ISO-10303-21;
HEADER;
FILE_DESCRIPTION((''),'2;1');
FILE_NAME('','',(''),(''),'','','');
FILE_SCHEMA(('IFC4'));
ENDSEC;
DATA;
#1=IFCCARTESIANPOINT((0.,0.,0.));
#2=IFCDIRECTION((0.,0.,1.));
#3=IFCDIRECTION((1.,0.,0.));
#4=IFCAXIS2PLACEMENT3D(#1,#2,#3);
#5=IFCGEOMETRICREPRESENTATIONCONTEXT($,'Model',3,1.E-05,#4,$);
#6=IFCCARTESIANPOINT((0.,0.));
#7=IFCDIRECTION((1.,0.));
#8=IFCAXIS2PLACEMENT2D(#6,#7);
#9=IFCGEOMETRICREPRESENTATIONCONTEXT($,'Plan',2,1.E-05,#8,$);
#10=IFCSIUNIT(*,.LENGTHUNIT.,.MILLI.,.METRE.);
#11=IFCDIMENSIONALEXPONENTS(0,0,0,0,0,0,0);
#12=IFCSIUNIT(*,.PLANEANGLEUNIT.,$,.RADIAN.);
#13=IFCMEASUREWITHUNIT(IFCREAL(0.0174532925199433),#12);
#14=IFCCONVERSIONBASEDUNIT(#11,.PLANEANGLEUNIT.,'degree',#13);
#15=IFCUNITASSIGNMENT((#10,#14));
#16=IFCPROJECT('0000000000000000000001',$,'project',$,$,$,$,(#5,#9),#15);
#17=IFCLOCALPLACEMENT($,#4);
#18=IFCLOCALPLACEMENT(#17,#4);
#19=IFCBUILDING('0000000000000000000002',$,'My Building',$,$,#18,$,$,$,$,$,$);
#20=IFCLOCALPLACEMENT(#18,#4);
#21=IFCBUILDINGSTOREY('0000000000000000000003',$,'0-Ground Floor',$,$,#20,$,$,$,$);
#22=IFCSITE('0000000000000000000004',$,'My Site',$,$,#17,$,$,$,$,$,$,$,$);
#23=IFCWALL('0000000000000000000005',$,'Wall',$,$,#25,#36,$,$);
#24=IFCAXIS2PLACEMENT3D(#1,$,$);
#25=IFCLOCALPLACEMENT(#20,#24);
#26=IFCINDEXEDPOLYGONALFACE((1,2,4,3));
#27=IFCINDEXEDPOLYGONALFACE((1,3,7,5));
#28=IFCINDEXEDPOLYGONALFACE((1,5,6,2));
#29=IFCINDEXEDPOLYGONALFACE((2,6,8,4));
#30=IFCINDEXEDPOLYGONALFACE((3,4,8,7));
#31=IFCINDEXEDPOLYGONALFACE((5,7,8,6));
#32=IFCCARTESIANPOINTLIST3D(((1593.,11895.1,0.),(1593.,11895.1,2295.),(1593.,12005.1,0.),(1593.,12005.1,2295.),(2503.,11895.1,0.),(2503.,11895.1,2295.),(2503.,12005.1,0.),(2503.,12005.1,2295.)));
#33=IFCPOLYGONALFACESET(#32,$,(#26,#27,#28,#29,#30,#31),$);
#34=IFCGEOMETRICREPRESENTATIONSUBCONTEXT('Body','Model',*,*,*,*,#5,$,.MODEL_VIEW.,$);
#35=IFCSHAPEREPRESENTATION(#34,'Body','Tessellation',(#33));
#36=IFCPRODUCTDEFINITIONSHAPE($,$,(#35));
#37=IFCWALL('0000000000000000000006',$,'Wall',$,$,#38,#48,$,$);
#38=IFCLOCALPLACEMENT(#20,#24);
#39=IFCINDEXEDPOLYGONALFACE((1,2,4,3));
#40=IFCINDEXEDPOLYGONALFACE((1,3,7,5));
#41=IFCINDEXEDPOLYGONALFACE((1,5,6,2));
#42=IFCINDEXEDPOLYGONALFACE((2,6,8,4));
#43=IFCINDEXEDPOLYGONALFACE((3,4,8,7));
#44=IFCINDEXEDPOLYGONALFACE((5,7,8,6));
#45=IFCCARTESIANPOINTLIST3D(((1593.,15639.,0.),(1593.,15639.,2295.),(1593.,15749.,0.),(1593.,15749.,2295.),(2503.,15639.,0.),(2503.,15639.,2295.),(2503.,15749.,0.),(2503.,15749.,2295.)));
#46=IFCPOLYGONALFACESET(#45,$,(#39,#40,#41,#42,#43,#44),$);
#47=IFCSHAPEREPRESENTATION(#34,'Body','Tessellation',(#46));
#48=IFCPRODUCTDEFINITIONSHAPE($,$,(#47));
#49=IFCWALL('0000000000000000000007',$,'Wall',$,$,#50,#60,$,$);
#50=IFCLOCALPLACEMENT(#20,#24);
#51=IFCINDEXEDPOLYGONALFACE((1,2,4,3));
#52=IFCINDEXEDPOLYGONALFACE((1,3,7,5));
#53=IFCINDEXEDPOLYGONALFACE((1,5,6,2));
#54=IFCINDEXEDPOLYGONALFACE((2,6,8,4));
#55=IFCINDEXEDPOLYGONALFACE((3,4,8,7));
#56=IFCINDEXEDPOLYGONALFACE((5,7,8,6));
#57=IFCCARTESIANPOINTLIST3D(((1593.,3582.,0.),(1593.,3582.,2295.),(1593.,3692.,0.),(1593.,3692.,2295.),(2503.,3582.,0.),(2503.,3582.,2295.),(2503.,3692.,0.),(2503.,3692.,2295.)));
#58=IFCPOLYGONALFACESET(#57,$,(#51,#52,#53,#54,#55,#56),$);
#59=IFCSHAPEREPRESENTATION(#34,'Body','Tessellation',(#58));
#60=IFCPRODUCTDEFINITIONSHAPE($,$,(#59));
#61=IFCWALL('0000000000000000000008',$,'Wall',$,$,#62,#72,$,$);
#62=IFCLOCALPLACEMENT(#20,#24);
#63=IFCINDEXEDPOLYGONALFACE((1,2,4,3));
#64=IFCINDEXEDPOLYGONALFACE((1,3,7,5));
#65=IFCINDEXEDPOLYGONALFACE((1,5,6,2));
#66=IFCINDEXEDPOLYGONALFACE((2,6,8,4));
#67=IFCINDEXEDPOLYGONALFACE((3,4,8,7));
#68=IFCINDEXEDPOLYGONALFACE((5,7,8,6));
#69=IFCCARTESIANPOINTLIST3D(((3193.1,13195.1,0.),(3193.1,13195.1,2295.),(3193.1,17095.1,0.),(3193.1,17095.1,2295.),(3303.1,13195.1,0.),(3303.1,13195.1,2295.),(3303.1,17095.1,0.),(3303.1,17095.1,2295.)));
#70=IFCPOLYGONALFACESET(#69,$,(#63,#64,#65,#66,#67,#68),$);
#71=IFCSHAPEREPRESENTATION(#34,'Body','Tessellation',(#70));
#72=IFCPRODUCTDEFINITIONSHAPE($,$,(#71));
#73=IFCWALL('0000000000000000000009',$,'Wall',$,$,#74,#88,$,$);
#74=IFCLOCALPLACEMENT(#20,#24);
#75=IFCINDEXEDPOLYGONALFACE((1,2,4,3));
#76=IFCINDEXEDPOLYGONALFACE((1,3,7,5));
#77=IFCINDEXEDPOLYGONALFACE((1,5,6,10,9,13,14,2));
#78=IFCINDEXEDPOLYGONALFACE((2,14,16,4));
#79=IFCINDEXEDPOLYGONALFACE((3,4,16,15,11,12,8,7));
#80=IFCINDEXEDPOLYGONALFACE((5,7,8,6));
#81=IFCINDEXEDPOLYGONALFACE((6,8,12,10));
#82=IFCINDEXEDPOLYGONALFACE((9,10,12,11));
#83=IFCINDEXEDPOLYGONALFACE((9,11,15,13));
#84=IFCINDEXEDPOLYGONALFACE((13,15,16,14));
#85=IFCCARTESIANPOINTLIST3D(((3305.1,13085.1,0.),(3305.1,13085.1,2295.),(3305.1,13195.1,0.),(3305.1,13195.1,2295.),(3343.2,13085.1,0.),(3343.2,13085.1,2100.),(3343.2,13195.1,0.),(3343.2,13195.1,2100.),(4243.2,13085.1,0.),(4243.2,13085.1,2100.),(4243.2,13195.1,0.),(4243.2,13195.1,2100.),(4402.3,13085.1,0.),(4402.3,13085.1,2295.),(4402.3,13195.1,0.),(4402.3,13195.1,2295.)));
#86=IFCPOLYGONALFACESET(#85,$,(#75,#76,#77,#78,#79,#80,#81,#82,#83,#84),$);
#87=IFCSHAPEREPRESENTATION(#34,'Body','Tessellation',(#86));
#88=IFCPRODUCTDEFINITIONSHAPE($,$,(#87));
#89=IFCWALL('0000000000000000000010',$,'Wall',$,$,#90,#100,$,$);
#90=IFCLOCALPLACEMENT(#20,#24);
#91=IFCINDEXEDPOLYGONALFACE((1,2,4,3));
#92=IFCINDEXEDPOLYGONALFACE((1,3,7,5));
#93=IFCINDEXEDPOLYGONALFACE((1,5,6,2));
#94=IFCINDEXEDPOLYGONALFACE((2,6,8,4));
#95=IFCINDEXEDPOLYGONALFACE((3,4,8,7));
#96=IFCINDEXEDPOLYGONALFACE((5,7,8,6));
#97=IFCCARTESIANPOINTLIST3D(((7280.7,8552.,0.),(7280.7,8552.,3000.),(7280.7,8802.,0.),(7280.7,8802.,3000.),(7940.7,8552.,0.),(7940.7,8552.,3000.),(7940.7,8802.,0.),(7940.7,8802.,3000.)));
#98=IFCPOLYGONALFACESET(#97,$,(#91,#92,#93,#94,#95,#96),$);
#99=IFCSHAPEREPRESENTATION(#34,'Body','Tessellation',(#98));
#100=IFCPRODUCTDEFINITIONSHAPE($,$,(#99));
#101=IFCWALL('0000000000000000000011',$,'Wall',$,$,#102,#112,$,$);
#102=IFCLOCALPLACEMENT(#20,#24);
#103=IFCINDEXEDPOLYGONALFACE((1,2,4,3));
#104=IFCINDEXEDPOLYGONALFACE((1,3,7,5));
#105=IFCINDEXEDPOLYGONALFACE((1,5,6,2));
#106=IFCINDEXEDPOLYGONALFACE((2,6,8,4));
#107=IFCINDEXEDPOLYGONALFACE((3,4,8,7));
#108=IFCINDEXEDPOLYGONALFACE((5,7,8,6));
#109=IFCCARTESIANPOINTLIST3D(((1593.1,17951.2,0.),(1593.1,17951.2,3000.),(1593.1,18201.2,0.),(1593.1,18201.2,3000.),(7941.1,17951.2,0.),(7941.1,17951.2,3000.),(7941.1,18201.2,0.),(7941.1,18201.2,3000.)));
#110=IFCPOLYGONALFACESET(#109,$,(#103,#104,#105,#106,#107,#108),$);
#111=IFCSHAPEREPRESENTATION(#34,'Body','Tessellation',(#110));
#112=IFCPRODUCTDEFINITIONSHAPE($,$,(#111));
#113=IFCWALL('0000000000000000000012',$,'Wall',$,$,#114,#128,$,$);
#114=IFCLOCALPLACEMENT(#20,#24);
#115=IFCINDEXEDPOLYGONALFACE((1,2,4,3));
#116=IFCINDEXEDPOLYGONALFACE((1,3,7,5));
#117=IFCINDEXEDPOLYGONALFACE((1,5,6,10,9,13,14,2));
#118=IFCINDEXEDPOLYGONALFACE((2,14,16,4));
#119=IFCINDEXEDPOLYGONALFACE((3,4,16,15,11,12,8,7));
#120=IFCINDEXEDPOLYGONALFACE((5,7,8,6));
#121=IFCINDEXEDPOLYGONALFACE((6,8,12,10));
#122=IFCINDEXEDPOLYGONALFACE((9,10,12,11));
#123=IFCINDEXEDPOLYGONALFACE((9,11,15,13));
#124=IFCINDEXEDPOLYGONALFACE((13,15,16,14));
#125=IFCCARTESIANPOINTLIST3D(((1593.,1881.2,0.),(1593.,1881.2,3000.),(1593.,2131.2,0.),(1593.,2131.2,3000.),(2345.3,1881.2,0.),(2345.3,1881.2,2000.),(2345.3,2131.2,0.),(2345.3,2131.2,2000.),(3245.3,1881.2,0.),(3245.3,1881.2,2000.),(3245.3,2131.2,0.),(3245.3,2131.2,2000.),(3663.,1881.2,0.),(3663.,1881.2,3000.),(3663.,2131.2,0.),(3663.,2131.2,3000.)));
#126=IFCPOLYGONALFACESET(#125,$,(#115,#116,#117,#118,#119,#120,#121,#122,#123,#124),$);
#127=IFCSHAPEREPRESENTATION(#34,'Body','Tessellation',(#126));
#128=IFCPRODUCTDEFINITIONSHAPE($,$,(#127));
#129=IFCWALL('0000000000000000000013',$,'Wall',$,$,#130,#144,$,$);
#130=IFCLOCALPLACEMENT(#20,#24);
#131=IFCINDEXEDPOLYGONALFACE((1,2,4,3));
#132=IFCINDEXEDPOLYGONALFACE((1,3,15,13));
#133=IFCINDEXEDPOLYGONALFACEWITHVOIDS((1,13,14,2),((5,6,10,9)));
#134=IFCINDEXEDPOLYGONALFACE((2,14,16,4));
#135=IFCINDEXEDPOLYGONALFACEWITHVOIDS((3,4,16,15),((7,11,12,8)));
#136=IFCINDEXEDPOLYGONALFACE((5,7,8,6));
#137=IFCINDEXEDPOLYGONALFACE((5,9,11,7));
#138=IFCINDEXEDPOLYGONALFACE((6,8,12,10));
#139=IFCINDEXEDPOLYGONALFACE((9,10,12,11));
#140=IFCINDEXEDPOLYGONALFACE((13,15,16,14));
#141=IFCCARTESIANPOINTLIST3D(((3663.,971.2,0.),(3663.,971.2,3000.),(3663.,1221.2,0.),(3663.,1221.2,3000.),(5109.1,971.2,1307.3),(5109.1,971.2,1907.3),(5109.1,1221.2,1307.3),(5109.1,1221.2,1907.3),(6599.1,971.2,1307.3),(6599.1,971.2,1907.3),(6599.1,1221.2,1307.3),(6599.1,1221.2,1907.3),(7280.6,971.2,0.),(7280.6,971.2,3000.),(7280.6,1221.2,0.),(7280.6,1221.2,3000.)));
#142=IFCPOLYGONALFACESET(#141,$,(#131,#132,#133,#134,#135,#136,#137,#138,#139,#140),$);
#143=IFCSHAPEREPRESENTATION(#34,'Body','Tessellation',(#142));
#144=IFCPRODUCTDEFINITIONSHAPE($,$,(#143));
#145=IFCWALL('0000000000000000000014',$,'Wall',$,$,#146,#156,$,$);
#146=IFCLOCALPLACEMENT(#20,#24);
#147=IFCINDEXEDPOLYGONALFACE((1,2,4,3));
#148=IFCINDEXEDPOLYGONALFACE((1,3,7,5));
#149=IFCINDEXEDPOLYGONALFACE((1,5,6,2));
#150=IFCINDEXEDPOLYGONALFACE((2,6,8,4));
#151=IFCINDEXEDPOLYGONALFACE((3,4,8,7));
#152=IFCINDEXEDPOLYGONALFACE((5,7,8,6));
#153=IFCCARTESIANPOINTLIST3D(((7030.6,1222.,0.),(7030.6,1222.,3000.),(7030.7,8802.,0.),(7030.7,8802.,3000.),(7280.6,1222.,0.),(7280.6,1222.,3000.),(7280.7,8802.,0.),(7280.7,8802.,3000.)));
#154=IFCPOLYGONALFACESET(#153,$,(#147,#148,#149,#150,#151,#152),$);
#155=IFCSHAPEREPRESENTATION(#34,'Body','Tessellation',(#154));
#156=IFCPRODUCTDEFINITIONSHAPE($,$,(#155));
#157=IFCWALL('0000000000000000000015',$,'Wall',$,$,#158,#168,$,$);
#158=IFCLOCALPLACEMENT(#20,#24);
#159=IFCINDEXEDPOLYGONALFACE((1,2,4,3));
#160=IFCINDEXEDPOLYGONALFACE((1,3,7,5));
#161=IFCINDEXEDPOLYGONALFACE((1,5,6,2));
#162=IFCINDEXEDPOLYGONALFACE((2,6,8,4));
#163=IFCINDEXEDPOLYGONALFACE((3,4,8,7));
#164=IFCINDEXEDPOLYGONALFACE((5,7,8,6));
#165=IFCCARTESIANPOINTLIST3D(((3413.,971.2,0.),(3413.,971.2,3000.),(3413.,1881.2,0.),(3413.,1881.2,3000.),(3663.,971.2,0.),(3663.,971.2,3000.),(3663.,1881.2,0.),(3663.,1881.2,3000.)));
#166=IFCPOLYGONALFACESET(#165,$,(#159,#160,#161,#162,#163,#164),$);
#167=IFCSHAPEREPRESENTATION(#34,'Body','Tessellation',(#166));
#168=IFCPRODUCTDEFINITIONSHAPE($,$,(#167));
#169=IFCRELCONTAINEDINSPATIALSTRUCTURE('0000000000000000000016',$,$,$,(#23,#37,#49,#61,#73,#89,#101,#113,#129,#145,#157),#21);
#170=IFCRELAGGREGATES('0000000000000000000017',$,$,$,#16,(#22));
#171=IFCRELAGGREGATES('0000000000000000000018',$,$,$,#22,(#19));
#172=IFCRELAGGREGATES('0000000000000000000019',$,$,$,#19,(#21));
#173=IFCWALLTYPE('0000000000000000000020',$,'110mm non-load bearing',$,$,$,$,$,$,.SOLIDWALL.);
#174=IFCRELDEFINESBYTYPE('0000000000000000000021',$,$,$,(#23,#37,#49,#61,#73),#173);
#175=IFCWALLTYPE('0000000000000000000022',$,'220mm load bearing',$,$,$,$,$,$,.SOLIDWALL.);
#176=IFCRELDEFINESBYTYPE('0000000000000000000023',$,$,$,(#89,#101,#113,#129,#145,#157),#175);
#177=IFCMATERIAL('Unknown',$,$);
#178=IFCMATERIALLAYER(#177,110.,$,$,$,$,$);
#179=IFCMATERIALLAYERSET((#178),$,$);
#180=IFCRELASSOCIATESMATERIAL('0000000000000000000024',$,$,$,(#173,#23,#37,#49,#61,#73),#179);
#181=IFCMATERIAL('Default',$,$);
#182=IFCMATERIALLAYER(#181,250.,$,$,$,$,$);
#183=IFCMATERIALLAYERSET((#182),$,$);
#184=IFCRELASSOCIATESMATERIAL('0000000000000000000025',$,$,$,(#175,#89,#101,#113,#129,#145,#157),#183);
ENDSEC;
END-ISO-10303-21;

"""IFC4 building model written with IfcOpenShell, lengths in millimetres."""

from ifc_helpers import new_model, entity, si_unit, converted_unit, frame, origin_with_axes, origin_2d_with_axis, place, context, subcontext, project, spatial, line, indexed_curve, outline, extrude, source, transform, mapped, material, layer, layer_set, layer_usage, type_object, element, save


model = new_model("IFC4")

# Units and contexts
model_context = context("Model", 3, precision=1e-05, world=origin_with_axes())
plan_context = context("Plan", 2, precision=1e-05, world=origin_2d_with_axis())
body_context_1 = subcontext(model_context, "Body", "Model", "MODEL_VIEW")
ifc_project = project(units=[si_unit("LENGTHUNIT", "METRE", prefix="MILLI"), converted_unit("PLANEANGLEUNIT", "degree", entity("IfcReal", 0.0174532925199433), si_unit("PLANEANGLEUNIT", "RADIAN"), dimensions=[0, 0, 0, 0, 0, 0, 0])], contexts=[model_context, plan_context])

# Site, building, storey
site_placement = place(None, origin_with_axes())
site = spatial("IfcSite", under=ifc_project, at=site_placement, Name="My Site")
building_placement = place(site_placement, origin_with_axes())
building = spatial("IfcBuilding", under=site, at=building_placement, Name="My Building")
storey_placement = place(building_placement, origin_with_axes())
storey = spatial("IfcBuildingStorey", under=building, at=storey_placement, Name="0-Ground Floor")

# Shared definitions
ifc_material_1 = material(Name="Unknown")
ifc_layer_1 = layer(ifc_material_1, 110.0)
ifc_layer_set_1 = layer_set([ifc_layer_1])
wall_type_1 = type_object("IfcWallType", Name="110mm non-load bearing", PredefinedType="SOLIDWALL", material=ifc_layer_set_1)

# Shared definitions
shared_shape_1 = source(origin_with_axes(), body_context_1, "Body", "SweptSolid", [
    extrude(outline(indexed_curve([(0.0, 0.0), (900.0, 0.0), (900.0, 2100.0), (0.0, 2100.0)], segments=[line(1, 2, 3, 4, 1)])), frame((0.0, -600.0, 0.0), z_axis=(0.0, -1.0, 0.0), x_axis=(1.0, 0.0, 0.0)), (0.0, 0.0, -1.0), 1200.0),
])

# Walls
ifc_layer_usage_1 = layer_usage(ifc_layer_set_1, "AXIS2", "POSITIVE", 0.0)
wall_1_placement = place(storey_placement, frame((1593.0, 11895.1, 0.0), z_axis=(0.0, 0.0, 1.0), x_axis=(1.0, 0.0, 0.0)))
element("IfcWall", 1, at=wall_1_placement, inside=storey, type_object=wall_type_1, material=ifc_layer_usage_1, Name="Wall", context=body_context_1, shape_type="SweptSolid", body=[
    extrude(outline(indexed_curve([(0.0, 0.0), (0.0, 110.0), (910.0, 110.0), (910.0, 0.0), (0.0, 0.0)], self_intersect=False)), origin_with_axes(), (0.0, 0.0, 1.0), 2295.0),
])
ifc_layer_usage_2 = layer_usage(ifc_layer_set_1, "AXIS2", "POSITIVE", 0.0)
wall_2_placement = place(storey_placement, frame((1593.0, 15639.0, 0.0), z_axis=(0.0, 0.0, 1.0), x_axis=(1.0, 0.0, 0.0)))
element("IfcWall", 2, at=wall_2_placement, inside=storey, type_object=wall_type_1, material=ifc_layer_usage_2, Name="Wall", context=body_context_1, shape_type="SweptSolid", body=[
    extrude(outline(indexed_curve([(0.0, 0.0), (0.0, 110.0), (910.0, 110.0), (910.0, 0.0), (0.0, 0.0)], self_intersect=False)), origin_with_axes(), (0.0, 0.0, 1.0), 2295.0),
])
ifc_layer_usage_3 = layer_usage(ifc_layer_set_1, "AXIS2", "POSITIVE", 0.0)
wall_3_placement = place(storey_placement, frame((1593.0, 3582.0, 0.0), z_axis=(0.0, 0.0, 1.0), x_axis=(1.0, 0.0, 0.0)))
element("IfcWall", 3, at=wall_3_placement, inside=storey, type_object=wall_type_1, material=ifc_layer_usage_3, Name="Wall", context=body_context_1, shape_type="SweptSolid", body=[
    extrude(outline(indexed_curve([(0.0, 0.0), (0.0, 110.0), (910.0, 110.0), (910.0, 0.0), (0.0, 0.0)], self_intersect=False)), origin_with_axes(), (0.0, 0.0, 1.0), 2295.0),
])
ifc_layer_usage_4 = layer_usage(ifc_layer_set_1, "AXIS2", "POSITIVE", 0.0)
wall_4_placement = place(storey_placement, frame((3303.1, 13195.1, 0.0), z_axis=(0.0, 0.0, 1.0), x_axis=(0.0, 1.0, 0.0)))
element("IfcWall", 4, at=wall_4_placement, inside=storey, type_object=wall_type_1, material=ifc_layer_usage_4, Name="Wall", context=body_context_1, shape_type="SweptSolid", body=[
    extrude(outline(indexed_curve([(0.0, 0.0), (0.0, 110.0), (3900.0, 110.0), (3900.0, 0.0), (0.0, 0.0)], self_intersect=False)), origin_with_axes(), (0.0, 0.0, 1.0), 2295.0),
])

# Wall, opening
ifc_layer_usage_5 = layer_usage(ifc_layer_set_1, "AXIS2", "POSITIVE", 0.0)
wall_5_placement = place(storey_placement, frame((3305.1, 13085.1, 0.0), z_axis=(0.0, 0.0, 1.0), x_axis=(1.0, 0.0, 0.0)))
wall_5 = element("IfcWall", 5, at=wall_5_placement, inside=storey, type_object=wall_type_1, material=ifc_layer_usage_5, Name="Wall", context=body_context_1, shape_type="SweptSolid", body=[
    extrude(outline(indexed_curve([(0.0, 0.0), (0.0, 110.0), (1097.3, 110.0), (1097.3, 0.0), (0.0, 0.0)], self_intersect=False)), origin_with_axes(), (0.0, 0.0, 1.0), 2295.0),
])
opening_1_placement = place(wall_5_placement, frame((38.2, 0.0, 0.0), z_axis=(0.0, 0.0, 1.0), x_axis=(1.0, 0.0, 0.0)))
element("IfcOpeningElement", 6, at=opening_1_placement, cuts=wall_5, PredefinedType="OPENING", context=body_context_1, shape_type="MappedRepresentation", body=[
    mapped(shared_shape_1, transform((0.0, 0.0, 0.0), x_axis=(1.0, 0.0, 0.0), y_axis=(0.0, 1.0, 0.0), z_axis=(0.0, 0.0, 1.0), scale=1.0)),
])

# Walls
ifc_material_2 = material(Name="Default")
ifc_layer_2 = layer(ifc_material_2, 250.0)
ifc_layer_set_2 = layer_set([ifc_layer_2])
ifc_layer_usage_6 = layer_usage(ifc_layer_set_2, "AXIS2", "POSITIVE", 0.0)
wall_type_2 = type_object("IfcWallType", Name="220mm load bearing", PredefinedType="SOLIDWALL", material=ifc_layer_set_2)
wall_6_placement = place(storey_placement, frame((7280.7, 8552.0, 0.0), z_axis=(0.0, 0.0, 1.0), x_axis=(1.0, 0.0, 0.0)))
element("IfcWall", 7, at=wall_6_placement, inside=storey, type_object=wall_type_2, material=ifc_layer_usage_6, Name="Wall", context=body_context_1, shape_type="SweptSolid", body=[
    extrude(outline(indexed_curve([(0.0, 0.0), (0.0, 250.0), (660.0, 250.0), (660.0, 0.0), (0.0, 0.0)], self_intersect=False)), origin_with_axes(), (0.0, 0.0, 1.0), 3000.0),
])
ifc_layer_usage_7 = layer_usage(ifc_layer_set_2, "AXIS2", "POSITIVE", 0.0)
wall_7_placement = place(storey_placement, frame((1593.1, 17951.2, 0.0), z_axis=(0.0, 0.0, 1.0), x_axis=(1.0, 0.0, 0.0)))
element("IfcWall", 8, at=wall_7_placement, inside=storey, type_object=wall_type_2, material=ifc_layer_usage_7, Name="Wall", context=body_context_1, shape_type="SweptSolid", body=[
    extrude(outline(indexed_curve([(0.0, 0.0), (0.0, 250.0), (6348.0, 250.0), (6348.0, 0.0), (0.0, 0.0)], self_intersect=False)), origin_with_axes(), (0.0, 0.0, 1.0), 3000.0),
])

# Walls, openings
ifc_layer_usage_8 = layer_usage(ifc_layer_set_2, "AXIS2", "POSITIVE", 0.0)
wall_8_placement = place(storey_placement, frame((1593.0, 1881.2, 0.0), z_axis=(0.0, 0.0, 1.0), x_axis=(1.0, 0.0, 0.0)))
wall_8 = element("IfcWall", 9, at=wall_8_placement, inside=storey, type_object=wall_type_2, material=ifc_layer_usage_8, Name="Wall", context=body_context_1, shape_type="SweptSolid", body=[
    extrude(outline(indexed_curve([(0.0, 0.0), (0.0, 250.0), (2070.0, 250.0), (2070.0, 0.0), (0.0, 0.0)], self_intersect=False)), origin_with_axes(), (0.0, 0.0, 1.0), 3000.0),
])
shared_shape_2 = source(origin_with_axes(), body_context_1, "Body", "SweptSolid", [
    extrude(outline(indexed_curve([(0.0, 0.0), (900.0, 0.0), (900.0, 2000.0), (0.0, 2000.0)], segments=[line(1, 2, 3, 4, 1)])), frame((0.0, -600.0, 0.0), z_axis=(0.0, -1.0, 0.0), x_axis=(1.0, 0.0, 0.0)), (0.0, 0.0, -1.0), 1200.0),
])
opening_2_placement = place(wall_8_placement, frame((752.2, 0.0, 0.0), z_axis=(0.0, 0.0, 1.0), x_axis=(1.0, 0.0, 0.0)))
element("IfcOpeningElement", 10, at=opening_2_placement, cuts=wall_8, PredefinedType="OPENING", context=body_context_1, shape_type="MappedRepresentation", body=[
    mapped(shared_shape_2, transform((0.0, 0.0, 0.0), x_axis=(1.0, 0.0, 0.0), y_axis=(0.0, 1.0, 0.0), z_axis=(0.0, 0.0, 1.0), scale=1.0)),
])
ifc_layer_usage_9 = layer_usage(ifc_layer_set_2, "AXIS2", "POSITIVE", 0.0)
wall_9_placement = place(storey_placement, frame((3663.0, 971.2, 0.0), z_axis=(0.0, 0.0, 1.0), x_axis=(1.0, 0.0, 0.0)))
wall_9 = element("IfcWall", 11, at=wall_9_placement, inside=storey, type_object=wall_type_2, material=ifc_layer_usage_9, Name="Wall", context=body_context_1, shape_type="SweptSolid", body=[
    extrude(outline(indexed_curve([(0.0, 0.0), (0.0, 250.0), (3617.6, 250.0), (3617.6, 0.0), (0.0, 0.0)], self_intersect=False)), origin_with_axes(), (0.0, 0.0, 1.0), 3000.0),
])
shared_shape_3 = source(origin_with_axes(), body_context_1, "Body", "SweptSolid", [
    extrude(outline(indexed_curve([(0.0, 0.0), (1490.0, 0.0), (1490.0, 600.0), (0.0, 600.0)], segments=[line(1, 2, 3, 4, 1)])), frame((0.0, -600.0, 0.0), z_axis=(0.0, -1.0, 0.0), x_axis=(1.0, 0.0, 0.0)), (0.0, 0.0, -1.0), 1200.0),
])
opening_3_placement = place(wall_9_placement, frame((1446.1, 0.0, 1307.3), z_axis=(0.0, 0.0, 1.0), x_axis=(1.0, 0.0, 0.0)))
element("IfcOpeningElement", 12, at=opening_3_placement, cuts=wall_9, PredefinedType="OPENING", context=body_context_1, shape_type="MappedRepresentation", body=[
    mapped(shared_shape_3, transform((0.0, 0.0, 0.0), x_axis=(1.0, 0.0, 0.0), y_axis=(0.0, 1.0, 0.0), z_axis=(0.0, 0.0, 1.0), scale=1.0)),
])

# Walls
ifc_layer_usage_10 = layer_usage(ifc_layer_set_2, "AXIS2", "POSITIVE", 0.0)
wall_10_placement = place(storey_placement, frame((7280.6, 1222.0, 0.0), z_axis=(0.0, 0.0, 1.0), x_axis=(0.0, 1.0, 0.0)))
element("IfcWall", 13, at=wall_10_placement, inside=storey, type_object=wall_type_2, material=ifc_layer_usage_10, Name="Wall", context=body_context_1, shape_type="SweptSolid", body=[
    extrude(outline(indexed_curve([(0.0, 0.0), (0.0, 250.0), (7580.0, 250.0), (7580.0, 0.0), (0.0, 0.0)], self_intersect=False)), origin_with_axes(), (0.0, 0.0, 1.0), 3000.0),
])
ifc_layer_usage_11 = layer_usage(ifc_layer_set_2, "AXIS2", "POSITIVE", 0.0)
wall_11_placement = place(storey_placement, frame((3663.0, 971.2, 0.0), z_axis=(0.0, 0.0, 1.0), x_axis=(0.0, 1.0, 0.0)))
element("IfcWall", 14, at=wall_11_placement, inside=storey, type_object=wall_type_2, material=ifc_layer_usage_11, Name="Wall", context=body_context_1, shape_type="SweptSolid", body=[
    extrude(outline(indexed_curve([(0.0, 0.0), (0.0, 250.0), (910.0, 250.0), (910.0, 0.0), (0.0, 0.0)], self_intersect=False)), origin_with_axes(), (0.0, 0.0, 1.0), 3000.0),
])

save(model, "model.ifc")
